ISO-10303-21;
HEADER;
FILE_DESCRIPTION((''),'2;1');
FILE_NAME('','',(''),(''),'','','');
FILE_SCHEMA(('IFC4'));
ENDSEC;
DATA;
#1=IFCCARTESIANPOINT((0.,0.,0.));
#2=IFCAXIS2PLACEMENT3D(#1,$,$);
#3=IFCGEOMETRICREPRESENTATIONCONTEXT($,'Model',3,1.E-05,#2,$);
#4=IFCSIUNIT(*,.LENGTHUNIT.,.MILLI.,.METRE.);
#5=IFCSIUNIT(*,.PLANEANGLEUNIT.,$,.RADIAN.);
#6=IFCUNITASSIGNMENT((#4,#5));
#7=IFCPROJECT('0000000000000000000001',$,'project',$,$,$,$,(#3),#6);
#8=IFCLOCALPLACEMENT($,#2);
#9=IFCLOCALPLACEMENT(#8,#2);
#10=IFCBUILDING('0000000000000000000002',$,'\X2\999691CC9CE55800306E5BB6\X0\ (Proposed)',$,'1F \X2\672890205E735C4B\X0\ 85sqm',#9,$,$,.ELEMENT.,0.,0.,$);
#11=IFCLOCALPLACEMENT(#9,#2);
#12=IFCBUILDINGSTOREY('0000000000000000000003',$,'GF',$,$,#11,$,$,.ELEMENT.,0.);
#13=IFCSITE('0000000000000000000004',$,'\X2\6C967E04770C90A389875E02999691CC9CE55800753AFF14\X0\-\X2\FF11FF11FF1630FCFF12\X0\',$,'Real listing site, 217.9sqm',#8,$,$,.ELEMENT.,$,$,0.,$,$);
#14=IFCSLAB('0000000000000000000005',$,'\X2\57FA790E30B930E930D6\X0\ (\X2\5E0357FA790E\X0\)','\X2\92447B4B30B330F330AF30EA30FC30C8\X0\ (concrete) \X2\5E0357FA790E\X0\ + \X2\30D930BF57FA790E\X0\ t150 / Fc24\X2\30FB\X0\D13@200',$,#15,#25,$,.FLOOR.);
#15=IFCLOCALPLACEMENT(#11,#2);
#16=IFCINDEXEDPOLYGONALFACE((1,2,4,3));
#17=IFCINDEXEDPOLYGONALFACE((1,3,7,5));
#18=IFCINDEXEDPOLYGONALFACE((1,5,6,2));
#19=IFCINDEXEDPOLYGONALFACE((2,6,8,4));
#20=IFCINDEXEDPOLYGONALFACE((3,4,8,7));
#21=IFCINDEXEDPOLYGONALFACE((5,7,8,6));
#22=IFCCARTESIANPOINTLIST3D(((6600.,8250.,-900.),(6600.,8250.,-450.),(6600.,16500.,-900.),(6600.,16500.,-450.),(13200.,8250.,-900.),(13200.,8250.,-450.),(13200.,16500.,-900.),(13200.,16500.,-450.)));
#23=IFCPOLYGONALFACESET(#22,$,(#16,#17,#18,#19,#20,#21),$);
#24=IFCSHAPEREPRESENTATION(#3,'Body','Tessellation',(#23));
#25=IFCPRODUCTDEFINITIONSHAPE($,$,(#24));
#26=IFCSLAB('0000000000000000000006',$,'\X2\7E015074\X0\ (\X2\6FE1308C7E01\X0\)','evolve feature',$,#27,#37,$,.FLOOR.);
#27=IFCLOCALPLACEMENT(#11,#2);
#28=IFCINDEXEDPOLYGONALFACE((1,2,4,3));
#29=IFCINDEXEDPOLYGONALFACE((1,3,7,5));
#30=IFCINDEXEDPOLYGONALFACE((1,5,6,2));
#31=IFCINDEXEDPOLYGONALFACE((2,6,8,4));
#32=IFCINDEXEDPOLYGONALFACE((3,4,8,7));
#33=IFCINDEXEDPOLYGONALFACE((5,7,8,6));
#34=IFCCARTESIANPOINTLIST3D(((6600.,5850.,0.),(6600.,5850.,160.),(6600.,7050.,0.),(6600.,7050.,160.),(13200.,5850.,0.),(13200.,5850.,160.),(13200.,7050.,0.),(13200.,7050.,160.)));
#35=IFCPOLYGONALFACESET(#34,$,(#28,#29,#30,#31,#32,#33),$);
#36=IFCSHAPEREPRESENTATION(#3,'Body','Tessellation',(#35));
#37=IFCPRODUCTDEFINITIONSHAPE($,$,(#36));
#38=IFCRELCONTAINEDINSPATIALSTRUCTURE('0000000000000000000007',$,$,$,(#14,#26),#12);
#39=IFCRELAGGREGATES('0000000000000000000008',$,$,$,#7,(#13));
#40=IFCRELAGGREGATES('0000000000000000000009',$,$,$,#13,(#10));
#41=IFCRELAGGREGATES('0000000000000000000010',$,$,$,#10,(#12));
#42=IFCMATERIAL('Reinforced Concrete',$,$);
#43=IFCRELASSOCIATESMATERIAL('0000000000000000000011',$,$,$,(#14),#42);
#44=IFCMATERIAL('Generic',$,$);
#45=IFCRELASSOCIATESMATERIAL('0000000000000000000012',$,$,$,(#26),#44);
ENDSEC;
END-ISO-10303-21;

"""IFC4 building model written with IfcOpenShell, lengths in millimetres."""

from ifc_helpers import new_model, si_unit, frame, frame_2d, origin, place, context, project, spatial, rectangle, extrude, material, element, save


model = new_model("IFC4")

# Units and contexts
model_context = context("Model", 3, precision=1e-05, world=origin())
ifc_project = project(units=[si_unit("LENGTHUNIT", "METRE", prefix="MILLI"), si_unit("PLANEANGLEUNIT", "RADIAN")], contexts=[model_context])

# Site, building, storey
site_placement = place(None, origin())
site = spatial("IfcSite", under=ifc_project, at=site_placement, Name="沖縄県那覇市首里鳥堀町４-１１６ー２", ObjectType="Real listing site, 217.9sqm", CompositionType="ELEMENT", RefElevation=0.0)
building_placement = place(site_placement, origin())
building = spatial("IfcBuilding", under=site, at=building_placement, Name="首里鳥堀の家 (Proposed)", ObjectType="1F 木造平屋 85sqm", CompositionType="ELEMENT", ElevationOfRefHeight=0.0, ElevationOfTerrain=0.0)
storey_placement = place(building_placement, origin())
storey = spatial("IfcBuildingStorey", under=building, at=storey_placement, Name="GF", CompositionType="ELEMENT", Elevation=0.0)

# Slabs
ifc_material_1 = material(Name="Reinforced Concrete")
slab_1_placement = place(storey_placement, frame((3300.0, 4125.0, -450.0)))
element("IfcSlab", 1, at=slab_1_placement, inside=storey, material=ifc_material_1, Name="基礎スラブ (布基礎)", Description="鉄筋コンクリート (concrete) 布基礎 + ベタ基礎 t150 / Fc24・D13@200", PredefinedType="FLOOR", context=model_context, shape_type="SweptSolid", body=[
    extrude(rectangle(XDim=6600.0, YDim=8250.0, at=frame_2d((3300.0, 4125.0))), frame((3300.0, 4125.0, -450.0)), (0.0, 0.0, 1.0), 450.0),
])
ifc_material_2 = material(Name="Generic")
slab_2_placement = place(storey_placement, frame((3300.0, 2925.0, 0.0)))
element("IfcSlab", 2, at=slab_2_placement, inside=storey, material=ifc_material_2, Name="縁側 (濡れ縁)", Description="evolve feature", PredefinedType="FLOOR", context=model_context, shape_type="SweptSolid", body=[
    extrude(rectangle(XDim=6600.0, YDim=1200.0, at=frame_2d((3300.0, 600.0))), frame((3300.0, 2925.0, 0.0)), (0.0, 0.0, 1.0), 160.0),
])

save(model, "model.ifc")
